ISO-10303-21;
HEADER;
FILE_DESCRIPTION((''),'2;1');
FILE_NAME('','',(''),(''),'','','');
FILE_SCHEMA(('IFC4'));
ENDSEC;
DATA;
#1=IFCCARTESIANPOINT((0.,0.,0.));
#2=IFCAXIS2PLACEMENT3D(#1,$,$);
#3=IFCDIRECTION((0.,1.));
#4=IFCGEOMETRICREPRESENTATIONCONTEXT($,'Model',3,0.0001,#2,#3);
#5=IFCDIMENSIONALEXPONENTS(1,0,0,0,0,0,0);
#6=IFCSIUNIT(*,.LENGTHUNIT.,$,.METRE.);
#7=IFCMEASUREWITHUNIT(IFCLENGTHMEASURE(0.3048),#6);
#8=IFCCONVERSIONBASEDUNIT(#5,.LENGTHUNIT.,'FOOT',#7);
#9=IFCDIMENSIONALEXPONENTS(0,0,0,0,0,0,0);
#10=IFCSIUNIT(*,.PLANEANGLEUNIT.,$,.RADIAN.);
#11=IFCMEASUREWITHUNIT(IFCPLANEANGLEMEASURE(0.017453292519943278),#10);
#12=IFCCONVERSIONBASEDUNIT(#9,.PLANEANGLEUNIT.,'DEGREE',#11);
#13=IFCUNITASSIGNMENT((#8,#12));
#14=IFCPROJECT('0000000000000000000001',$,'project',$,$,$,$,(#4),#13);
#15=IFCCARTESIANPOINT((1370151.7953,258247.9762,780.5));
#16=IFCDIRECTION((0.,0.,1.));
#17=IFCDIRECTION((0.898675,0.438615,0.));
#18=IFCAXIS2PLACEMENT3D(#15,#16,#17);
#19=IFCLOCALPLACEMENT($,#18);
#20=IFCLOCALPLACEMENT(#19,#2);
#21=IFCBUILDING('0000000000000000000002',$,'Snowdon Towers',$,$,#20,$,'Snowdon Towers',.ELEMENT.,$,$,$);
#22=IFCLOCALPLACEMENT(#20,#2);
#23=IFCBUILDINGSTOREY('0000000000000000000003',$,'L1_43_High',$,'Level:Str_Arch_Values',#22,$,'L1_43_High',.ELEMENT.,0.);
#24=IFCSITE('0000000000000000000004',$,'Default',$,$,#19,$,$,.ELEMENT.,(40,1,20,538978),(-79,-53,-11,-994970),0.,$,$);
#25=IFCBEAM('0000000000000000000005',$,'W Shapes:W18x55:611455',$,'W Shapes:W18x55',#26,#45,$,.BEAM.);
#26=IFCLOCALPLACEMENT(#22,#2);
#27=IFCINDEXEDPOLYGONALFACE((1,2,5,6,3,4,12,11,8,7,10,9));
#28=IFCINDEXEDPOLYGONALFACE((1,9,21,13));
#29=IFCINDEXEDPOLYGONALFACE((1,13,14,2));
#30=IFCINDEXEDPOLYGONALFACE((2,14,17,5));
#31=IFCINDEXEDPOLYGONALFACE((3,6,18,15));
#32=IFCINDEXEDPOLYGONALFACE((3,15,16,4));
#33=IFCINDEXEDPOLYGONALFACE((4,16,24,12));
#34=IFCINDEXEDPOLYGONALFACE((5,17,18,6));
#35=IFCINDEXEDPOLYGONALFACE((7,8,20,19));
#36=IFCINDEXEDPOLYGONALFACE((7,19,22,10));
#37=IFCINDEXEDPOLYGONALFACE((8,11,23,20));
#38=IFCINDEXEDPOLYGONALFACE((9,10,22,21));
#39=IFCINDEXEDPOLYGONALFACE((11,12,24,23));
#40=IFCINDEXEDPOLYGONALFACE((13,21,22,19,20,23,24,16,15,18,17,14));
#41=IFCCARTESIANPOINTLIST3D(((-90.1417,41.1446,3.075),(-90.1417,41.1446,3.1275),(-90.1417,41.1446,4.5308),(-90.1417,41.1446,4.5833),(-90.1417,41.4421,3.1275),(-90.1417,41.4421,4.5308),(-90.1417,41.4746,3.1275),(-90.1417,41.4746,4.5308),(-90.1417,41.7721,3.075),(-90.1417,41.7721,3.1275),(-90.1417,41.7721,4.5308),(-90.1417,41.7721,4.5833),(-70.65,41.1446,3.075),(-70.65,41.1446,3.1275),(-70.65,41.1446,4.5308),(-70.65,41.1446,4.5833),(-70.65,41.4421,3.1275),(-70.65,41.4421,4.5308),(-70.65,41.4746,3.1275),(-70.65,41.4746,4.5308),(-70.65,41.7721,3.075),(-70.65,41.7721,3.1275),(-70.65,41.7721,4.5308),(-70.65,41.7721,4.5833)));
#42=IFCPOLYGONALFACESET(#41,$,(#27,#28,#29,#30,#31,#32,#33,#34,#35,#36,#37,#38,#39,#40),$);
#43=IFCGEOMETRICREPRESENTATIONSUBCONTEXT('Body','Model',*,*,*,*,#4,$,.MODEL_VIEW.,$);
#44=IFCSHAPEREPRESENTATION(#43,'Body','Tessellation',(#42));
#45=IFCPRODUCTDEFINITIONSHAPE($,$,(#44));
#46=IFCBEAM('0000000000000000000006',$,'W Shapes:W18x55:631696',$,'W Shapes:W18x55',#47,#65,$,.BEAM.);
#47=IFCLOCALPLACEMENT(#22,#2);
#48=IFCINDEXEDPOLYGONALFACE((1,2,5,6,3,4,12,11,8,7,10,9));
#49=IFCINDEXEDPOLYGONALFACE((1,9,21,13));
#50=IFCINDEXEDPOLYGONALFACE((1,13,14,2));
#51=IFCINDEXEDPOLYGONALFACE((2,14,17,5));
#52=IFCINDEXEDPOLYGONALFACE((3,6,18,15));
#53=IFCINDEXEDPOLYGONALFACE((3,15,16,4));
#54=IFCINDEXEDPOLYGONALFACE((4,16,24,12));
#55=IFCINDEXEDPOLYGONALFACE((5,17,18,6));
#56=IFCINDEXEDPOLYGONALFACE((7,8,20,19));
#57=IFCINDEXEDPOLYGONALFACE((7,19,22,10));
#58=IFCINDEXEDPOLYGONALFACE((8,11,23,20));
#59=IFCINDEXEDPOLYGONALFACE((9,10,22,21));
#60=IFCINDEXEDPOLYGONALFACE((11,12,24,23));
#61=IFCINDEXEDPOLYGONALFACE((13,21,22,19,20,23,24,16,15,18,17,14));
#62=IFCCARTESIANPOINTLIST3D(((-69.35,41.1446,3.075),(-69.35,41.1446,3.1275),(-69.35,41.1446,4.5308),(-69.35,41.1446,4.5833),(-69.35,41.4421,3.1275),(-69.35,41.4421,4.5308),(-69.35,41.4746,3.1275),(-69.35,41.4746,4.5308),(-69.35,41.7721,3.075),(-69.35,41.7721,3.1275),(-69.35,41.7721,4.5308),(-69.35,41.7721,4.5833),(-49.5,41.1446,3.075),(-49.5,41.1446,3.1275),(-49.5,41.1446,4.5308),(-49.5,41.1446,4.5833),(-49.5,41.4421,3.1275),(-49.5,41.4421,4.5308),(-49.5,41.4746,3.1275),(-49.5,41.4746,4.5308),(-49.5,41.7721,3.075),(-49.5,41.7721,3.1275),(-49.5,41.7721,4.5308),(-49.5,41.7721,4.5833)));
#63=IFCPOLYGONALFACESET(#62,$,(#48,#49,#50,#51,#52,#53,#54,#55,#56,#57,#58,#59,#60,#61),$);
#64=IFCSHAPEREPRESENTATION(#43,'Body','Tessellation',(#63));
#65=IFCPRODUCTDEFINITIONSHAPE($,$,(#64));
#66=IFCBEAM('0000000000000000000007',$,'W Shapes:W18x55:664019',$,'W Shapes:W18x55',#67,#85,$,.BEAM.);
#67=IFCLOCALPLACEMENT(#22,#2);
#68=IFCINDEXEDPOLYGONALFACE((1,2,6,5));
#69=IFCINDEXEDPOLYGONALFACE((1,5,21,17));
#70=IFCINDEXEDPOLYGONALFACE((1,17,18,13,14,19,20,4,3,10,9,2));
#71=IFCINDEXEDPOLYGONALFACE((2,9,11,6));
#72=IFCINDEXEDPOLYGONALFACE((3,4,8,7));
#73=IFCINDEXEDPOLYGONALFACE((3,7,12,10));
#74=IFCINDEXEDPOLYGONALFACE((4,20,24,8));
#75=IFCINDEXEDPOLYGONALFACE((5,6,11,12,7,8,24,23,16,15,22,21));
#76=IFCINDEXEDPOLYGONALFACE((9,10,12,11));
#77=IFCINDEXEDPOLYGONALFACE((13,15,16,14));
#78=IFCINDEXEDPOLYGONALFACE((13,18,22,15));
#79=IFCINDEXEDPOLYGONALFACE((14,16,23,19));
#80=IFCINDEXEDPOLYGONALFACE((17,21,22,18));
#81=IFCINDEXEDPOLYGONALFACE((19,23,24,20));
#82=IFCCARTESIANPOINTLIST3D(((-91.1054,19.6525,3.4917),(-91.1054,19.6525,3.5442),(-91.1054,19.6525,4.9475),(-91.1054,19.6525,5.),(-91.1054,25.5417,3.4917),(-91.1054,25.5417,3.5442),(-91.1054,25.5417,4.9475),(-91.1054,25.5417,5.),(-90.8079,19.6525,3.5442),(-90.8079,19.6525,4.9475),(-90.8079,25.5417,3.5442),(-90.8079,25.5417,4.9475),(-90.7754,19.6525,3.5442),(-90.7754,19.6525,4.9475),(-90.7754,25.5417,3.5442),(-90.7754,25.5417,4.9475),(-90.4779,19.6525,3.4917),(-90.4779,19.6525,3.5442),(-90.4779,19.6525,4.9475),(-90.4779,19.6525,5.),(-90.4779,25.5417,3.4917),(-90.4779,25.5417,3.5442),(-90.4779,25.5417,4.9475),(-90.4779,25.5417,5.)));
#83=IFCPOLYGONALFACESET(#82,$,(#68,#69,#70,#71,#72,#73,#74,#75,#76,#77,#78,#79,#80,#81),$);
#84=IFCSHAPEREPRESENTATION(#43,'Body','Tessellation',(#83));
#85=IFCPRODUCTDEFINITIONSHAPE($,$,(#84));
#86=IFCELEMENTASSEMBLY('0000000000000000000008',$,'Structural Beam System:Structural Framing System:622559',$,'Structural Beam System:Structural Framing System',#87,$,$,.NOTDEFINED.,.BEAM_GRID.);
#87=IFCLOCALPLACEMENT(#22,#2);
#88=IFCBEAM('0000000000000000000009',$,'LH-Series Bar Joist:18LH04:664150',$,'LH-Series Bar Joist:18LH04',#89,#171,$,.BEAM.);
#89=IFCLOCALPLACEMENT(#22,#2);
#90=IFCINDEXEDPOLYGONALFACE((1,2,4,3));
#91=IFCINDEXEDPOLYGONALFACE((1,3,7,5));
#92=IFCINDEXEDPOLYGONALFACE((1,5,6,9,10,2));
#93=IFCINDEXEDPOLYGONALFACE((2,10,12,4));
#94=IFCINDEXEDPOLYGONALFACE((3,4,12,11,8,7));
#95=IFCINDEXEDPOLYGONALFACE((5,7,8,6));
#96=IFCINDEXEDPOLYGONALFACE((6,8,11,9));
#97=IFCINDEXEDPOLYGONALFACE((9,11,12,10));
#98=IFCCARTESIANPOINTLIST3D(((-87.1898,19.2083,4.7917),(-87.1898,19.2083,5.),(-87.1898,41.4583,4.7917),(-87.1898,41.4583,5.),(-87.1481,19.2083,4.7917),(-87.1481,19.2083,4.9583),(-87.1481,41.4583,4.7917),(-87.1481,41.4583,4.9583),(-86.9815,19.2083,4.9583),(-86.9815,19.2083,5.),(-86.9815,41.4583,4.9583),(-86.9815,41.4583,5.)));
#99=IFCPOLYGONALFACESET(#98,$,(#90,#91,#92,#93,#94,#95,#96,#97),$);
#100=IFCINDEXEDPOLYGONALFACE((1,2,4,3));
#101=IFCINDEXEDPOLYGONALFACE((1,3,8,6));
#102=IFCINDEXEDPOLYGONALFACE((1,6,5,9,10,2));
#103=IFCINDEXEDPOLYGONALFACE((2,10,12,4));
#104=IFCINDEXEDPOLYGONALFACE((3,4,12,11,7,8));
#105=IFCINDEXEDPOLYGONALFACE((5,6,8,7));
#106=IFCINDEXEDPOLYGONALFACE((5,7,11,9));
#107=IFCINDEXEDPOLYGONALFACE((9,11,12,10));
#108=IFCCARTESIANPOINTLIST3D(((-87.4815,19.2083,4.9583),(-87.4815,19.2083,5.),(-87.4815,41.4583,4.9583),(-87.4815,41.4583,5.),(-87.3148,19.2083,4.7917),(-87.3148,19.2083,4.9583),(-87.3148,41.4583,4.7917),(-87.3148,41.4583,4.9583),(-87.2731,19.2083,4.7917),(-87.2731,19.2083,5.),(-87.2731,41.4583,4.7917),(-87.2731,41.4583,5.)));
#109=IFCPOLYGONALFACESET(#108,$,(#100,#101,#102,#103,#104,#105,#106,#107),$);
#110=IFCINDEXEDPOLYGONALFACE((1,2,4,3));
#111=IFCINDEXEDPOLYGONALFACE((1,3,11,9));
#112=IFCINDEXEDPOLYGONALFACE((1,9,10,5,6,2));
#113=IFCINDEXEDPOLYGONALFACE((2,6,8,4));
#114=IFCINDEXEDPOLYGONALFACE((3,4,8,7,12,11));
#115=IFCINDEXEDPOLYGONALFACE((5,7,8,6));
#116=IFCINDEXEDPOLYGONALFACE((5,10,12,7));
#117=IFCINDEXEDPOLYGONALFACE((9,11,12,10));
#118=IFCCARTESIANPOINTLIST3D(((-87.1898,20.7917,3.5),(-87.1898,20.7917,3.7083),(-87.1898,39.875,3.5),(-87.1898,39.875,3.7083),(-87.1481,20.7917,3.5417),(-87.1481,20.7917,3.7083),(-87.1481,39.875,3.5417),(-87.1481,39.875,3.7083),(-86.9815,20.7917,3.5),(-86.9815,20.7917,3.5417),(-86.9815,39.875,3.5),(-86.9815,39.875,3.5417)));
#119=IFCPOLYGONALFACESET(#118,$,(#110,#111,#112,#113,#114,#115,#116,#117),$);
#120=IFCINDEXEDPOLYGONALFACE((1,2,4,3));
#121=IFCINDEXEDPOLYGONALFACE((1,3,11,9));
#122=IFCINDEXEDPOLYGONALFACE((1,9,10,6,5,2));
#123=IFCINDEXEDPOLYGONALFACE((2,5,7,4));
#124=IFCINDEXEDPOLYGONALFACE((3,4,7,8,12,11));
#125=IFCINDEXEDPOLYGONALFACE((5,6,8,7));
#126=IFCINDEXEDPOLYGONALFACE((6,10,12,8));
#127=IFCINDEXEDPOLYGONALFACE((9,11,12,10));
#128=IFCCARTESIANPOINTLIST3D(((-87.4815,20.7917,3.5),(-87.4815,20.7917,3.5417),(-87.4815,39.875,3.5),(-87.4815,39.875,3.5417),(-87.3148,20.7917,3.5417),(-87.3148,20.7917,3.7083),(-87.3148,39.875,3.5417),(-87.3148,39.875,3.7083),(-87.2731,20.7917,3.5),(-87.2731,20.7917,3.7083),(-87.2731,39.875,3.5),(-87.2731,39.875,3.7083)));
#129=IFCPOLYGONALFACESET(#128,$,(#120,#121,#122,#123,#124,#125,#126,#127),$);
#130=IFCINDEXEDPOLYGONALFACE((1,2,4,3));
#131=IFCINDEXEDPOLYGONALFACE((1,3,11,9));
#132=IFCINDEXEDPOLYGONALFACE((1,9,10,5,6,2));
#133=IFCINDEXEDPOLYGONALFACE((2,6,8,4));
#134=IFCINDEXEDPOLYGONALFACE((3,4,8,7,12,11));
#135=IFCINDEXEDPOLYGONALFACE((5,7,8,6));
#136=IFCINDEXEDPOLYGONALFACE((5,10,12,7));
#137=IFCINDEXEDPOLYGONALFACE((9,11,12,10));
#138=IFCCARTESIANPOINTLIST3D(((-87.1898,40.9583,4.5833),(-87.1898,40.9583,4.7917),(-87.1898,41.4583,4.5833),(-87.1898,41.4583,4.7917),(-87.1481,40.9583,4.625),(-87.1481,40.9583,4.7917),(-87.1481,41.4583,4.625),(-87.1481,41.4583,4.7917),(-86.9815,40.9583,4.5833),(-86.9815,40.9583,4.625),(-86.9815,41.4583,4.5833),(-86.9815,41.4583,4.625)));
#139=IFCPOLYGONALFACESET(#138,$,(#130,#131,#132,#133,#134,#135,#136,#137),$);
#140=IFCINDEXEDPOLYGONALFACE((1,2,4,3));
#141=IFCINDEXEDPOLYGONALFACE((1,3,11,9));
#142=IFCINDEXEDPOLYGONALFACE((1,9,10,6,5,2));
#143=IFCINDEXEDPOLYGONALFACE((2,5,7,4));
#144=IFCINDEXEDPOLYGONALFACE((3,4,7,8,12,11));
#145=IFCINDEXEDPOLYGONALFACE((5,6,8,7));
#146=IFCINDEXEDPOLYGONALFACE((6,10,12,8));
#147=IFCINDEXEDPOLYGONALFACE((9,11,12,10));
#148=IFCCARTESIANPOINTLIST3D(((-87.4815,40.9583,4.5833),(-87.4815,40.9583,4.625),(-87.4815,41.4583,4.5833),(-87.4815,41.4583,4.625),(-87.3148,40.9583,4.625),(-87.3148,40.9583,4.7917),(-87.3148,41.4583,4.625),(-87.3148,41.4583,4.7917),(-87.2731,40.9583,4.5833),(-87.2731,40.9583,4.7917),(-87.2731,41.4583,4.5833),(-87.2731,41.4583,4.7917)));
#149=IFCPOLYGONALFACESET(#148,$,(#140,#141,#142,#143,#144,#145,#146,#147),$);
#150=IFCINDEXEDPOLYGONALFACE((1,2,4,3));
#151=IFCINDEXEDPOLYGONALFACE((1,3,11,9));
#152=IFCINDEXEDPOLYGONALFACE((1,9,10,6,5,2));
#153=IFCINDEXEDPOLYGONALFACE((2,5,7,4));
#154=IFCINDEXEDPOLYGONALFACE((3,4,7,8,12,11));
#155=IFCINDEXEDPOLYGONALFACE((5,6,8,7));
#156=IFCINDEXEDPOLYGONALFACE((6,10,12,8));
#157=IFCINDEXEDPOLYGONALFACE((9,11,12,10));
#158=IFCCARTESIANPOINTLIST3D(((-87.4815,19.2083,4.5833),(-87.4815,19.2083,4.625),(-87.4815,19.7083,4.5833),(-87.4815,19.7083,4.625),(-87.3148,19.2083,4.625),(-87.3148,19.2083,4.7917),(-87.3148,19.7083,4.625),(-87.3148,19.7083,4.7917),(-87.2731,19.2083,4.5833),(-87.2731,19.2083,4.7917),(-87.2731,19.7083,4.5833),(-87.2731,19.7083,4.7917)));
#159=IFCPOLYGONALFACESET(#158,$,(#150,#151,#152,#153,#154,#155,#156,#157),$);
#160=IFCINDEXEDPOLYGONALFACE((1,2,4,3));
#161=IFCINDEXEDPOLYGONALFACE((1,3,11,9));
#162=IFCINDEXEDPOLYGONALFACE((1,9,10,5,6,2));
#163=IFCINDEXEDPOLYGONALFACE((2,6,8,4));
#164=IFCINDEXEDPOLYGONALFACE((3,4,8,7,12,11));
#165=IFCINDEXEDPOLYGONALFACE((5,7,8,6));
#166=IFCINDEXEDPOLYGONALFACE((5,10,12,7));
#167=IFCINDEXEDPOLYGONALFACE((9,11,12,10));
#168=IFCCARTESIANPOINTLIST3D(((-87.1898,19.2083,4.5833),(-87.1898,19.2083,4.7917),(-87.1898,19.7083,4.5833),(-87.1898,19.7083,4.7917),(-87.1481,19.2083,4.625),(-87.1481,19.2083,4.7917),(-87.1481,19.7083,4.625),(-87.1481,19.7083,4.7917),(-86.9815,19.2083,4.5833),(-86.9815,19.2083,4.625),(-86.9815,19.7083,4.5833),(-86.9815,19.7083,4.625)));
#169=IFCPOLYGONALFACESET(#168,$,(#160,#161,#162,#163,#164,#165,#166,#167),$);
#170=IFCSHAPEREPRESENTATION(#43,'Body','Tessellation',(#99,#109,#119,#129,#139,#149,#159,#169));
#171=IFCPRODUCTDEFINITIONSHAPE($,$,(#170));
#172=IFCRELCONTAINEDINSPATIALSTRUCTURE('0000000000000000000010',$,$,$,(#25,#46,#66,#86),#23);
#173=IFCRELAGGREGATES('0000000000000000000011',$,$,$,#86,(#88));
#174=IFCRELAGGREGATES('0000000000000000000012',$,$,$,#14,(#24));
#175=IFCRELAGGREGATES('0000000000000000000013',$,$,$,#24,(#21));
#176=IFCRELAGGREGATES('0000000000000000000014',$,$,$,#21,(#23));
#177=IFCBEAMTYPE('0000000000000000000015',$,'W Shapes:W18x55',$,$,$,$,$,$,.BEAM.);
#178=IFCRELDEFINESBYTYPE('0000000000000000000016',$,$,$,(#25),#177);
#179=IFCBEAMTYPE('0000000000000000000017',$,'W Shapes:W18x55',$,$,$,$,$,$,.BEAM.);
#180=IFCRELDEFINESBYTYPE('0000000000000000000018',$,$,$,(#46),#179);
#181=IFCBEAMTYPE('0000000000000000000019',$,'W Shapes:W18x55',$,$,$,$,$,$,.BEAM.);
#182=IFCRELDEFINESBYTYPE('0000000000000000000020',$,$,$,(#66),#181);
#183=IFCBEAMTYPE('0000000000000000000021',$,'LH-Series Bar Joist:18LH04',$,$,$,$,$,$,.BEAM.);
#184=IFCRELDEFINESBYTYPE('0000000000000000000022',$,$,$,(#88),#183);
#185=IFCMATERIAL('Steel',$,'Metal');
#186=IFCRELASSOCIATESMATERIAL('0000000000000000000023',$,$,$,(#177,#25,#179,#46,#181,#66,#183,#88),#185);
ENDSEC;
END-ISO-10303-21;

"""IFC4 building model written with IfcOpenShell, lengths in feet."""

from ifc_helpers import new_model, entity, si_unit, converted_unit, direction, frame, origin, place, context, subcontext, project, spatial, indexed_curve, outline, extrude, source, transform, mapped, material, type_object, type_shapes, element, aggregate, save


model = new_model("IFC4")

# Units and contexts
model_context = context("Model", 3, precision=0.0001, world=origin(), true_north=direction((0.0, 1.0)))
body_context = subcontext(model_context, "Body", "Model", "MODEL_VIEW")
ifc_project = project(units=[converted_unit("LENGTHUNIT", "FOOT", entity("IfcLengthMeasure", 0.3048), si_unit("LENGTHUNIT", "METRE"), dimensions=[1, 0, 0, 0, 0, 0, 0]), converted_unit("PLANEANGLEUNIT", "DEGREE", entity("IfcPlaneAngleMeasure", 0.017453292519943278), si_unit("PLANEANGLEUNIT", "RADIAN"), dimensions=[0, 0, 0, 0, 0, 0, 0])], contexts=[model_context])

# Site, building, storey
site_placement = place(None, frame((1370151.7953, 258247.9762, 780.5), z_axis=(0.0, 0.0, 1.0), x_axis=(0.898675, 0.438615, 0.0)))
site = spatial("IfcSite", under=ifc_project, at=site_placement, Name="Default", CompositionType="ELEMENT", RefLatitude=(40, 1, 20, 538978), RefLongitude=(-79, -53, -11, -994970), RefElevation=0.0)
building_placement = place(site_placement, origin())
building = spatial("IfcBuilding", under=site, at=building_placement, Name="Snowdon Towers", LongName="Snowdon Towers", CompositionType="ELEMENT")
storey_placement = place(building_placement, origin())
storey = spatial("IfcBuildingStorey", under=building, at=storey_placement, Name="L1_43_High", ObjectType="Level:Str_Arch_Values", LongName="L1_43_High", CompositionType="ELEMENT", Elevation=0.0)

# Shared definitions
ifc_material_1 = material(Name="Steel", Category="Metal")

# Beams
beam_type_1 = type_object("IfcBeamType", Name="W Shapes:W18x55", PredefinedType="BEAM", material=ifc_material_1)
shared_shape_1 = source(origin(), body_context, "Body", "SweptSolid", [
    extrude(outline(indexed_curve([(-0.3138, -0.7017), (-0.3138, -0.7542), (0.3138, -0.7542), (0.3138, -0.7017), (0.0162, -0.7017), (0.0162, 0.7017), (0.3138, 0.7017), (0.3138, 0.7542), (-0.3137, 0.7542), (-0.3137, 0.7017), (-0.0163, 0.7017), (-0.0163, -0.7017), (-0.3138, -0.7017)], self_intersect=False)), frame((-9.7875, 0.0, 0.0), z_axis=(-1.0, 0.0, 0.0), x_axis=(0.0, -1.0, 0.0)), (0.0, 0.0, -1.0), 19.4917),
])
type_shapes(beam_type_1, [shared_shape_1])
beam_1_placement = place(storey_placement, frame((-80.3542, 41.4583, 3.8292)))
element("IfcBeam", 1, at=beam_1_placement, inside=storey, type_object=beam_type_1, material=ifc_material_1, Name="W Shapes:W18x55:611455", ObjectType="W Shapes:W18x55", PredefinedType="BEAM", context=body_context, shape_type="MappedRepresentation", body=[
    mapped(shared_shape_1, transform((0.0, 0.0, 0.0), scale=1.0)),
])
beam_type_2 = type_object("IfcBeamType", Name="W Shapes:W18x55", PredefinedType="BEAM", material=ifc_material_1)
shared_shape_2 = source(origin(), body_context, "Body", "SweptSolid", [
    extrude(outline(indexed_curve([(-0.3138, -0.7017), (-0.3138, -0.7542), (0.3138, -0.7542), (0.3138, -0.7017), (0.0162, -0.7017), (0.0162, 0.7017), (0.3138, 0.7017), (0.3138, 0.7542), (-0.3137, 0.7542), (-0.3137, 0.7017), (-0.0163, 0.7017), (-0.0163, -0.7017), (-0.3138, -0.7017)], self_intersect=False)), frame((-9.725, 0.0, 0.0), z_axis=(-1.0, 0.0, 0.0), x_axis=(0.0, -1.0, 0.0)), (0.0, 0.0, -1.0), 19.85),
])
type_shapes(beam_type_2, [shared_shape_2])
beam_2_placement = place(storey_placement, frame((-59.625, 41.4583, 3.8292)))
element("IfcBeam", 2, at=beam_2_placement, inside=storey, type_object=beam_type_2, material=ifc_material_1, Name="W Shapes:W18x55:631696", ObjectType="W Shapes:W18x55", PredefinedType="BEAM", context=body_context, shape_type="MappedRepresentation", body=[
    mapped(shared_shape_2, transform((0.0, 0.0, 0.0), scale=1.0)),
])
beam_type_3 = type_object("IfcBeamType", Name="W Shapes:W18x55", PredefinedType="BEAM", material=ifc_material_1)
shared_shape_3 = source(origin(), body_context, "Body", "SweptSolid", [
    extrude(outline(indexed_curve([(-0.3138, -0.7017), (-0.3138, -0.7542), (0.3138, -0.7542), (0.3138, -0.7017), (0.0162, -0.7017), (0.0162, 0.7017), (0.3138, 0.7017), (0.3138, 0.7542), (-0.3137, 0.7542), (-0.3137, 0.7017), (-0.0163, 0.7017), (-0.0163, -0.7017), (-0.3138, -0.7017)], self_intersect=False)), frame((-2.7154, 0.0, 0.0), z_axis=(-1.0, 0.0, 0.0), x_axis=(0.0, -1.0, 0.0)), (0.0, 0.0, -1.0), 5.8892),
])
type_shapes(beam_type_3, [shared_shape_3])
beam_3_placement = place(storey_placement, frame((-90.7917, 22.3679, 4.2458), z_axis=(0.0, 0.0, 1.0), x_axis=(0.0, 1.0, 0.0)))
element("IfcBeam", 3, at=beam_3_placement, inside=storey, type_object=beam_type_3, material=ifc_material_1, Name="W Shapes:W18x55:664019", ObjectType="W Shapes:W18x55", PredefinedType="BEAM", context=body_context, shape_type="MappedRepresentation", body=[
    mapped(shared_shape_3, transform((0.0, 0.0, 0.0), scale=1.0)),
])

# Element assembly, beam
assembly_placement = place(storey_placement, origin())
assembly = element("IfcElementAssembly", 4, at=assembly_placement, inside=storey, Name="Structural Beam System:Structural Framing System:622559", ObjectType="Structural Beam System:Structural Framing System", AssemblyPlace="NOTDEFINED", PredefinedType="BEAM_GRID")
beam_type_4 = type_object("IfcBeamType", Name="LH-Series Bar Joist:18LH04", PredefinedType="BEAM", material=ifc_material_1)
shared_shape_4 = source(origin(), body_context, "Body", "SweptSolid", [
    extrude(outline(indexed_curve([(-0.0833, -0.0833), (0.125, -0.0833), (0.125, -0.0417), (-0.0417, -0.0417), (-0.0417, 0.125), (-0.0833, 0.125), (-0.0833, -0.0833)], self_intersect=False)), frame((-11.125, -0.125, 0.6667), z_axis=(1.0, 0.0, 0.0), x_axis=(0.0, -1.0, 0.0)), (0.0, 0.0, 1.0), 22.25),
    extrude(outline(indexed_curve([(-0.0833, -0.0833), (0.125, -0.0833), (0.125, -0.0417), (-0.0417, -0.0417), (-0.0417, 0.125), (-0.0833, 0.125), (-0.0833, -0.0833)], self_intersect=False)), frame((-11.125, 0.125, 0.6667), z_axis=(1.0, 0.0, 0.0), x_axis=(0.0, 0.0, -1.0)), (0.0, 0.0, 1.0), 22.25),
    extrude(outline(indexed_curve([(-0.0833, -0.0833), (0.125, -0.0833), (0.125, -0.0417), (-0.0417, -0.0417), (-0.0417, 0.125), (-0.0833, 0.125), (-0.0833, -0.0833)], self_intersect=False)), frame((-9.5417, -0.125, -0.6667), z_axis=(1.0, 0.0, 0.0), x_axis=(0.0, 0.0, 1.0)), (0.0, 0.0, 1.0), 19.0833),
    extrude(outline(indexed_curve([(-0.0833, -0.0833), (0.125, -0.0833), (0.125, -0.0417), (-0.0417, -0.0417), (-0.0417, 0.125), (-0.0833, 0.125), (-0.0833, -0.0833)], self_intersect=False)), frame((-9.5417, 0.125, -0.6667), z_axis=(1.0, 0.0, 0.0), x_axis=(0.0, 1.0, 0.0)), (0.0, 0.0, 1.0), 19.0833),
    extrude(outline(indexed_curve([(-0.0833, -0.0833), (0.125, -0.0833), (0.125, -0.0417), (-0.0417, -0.0417), (-0.0417, 0.125), (-0.0833, 0.125), (-0.0833, -0.0833)], self_intersect=False)), frame((10.625, -0.125, 0.4167), z_axis=(1.0, 0.0, 0.0), x_axis=(0.0, 0.0, 1.0)), (0.0, 0.0, 1.0), 0.5),
    extrude(outline(indexed_curve([(-0.0833, -0.0833), (0.125, -0.0833), (0.125, -0.0417), (-0.0417, -0.0417), (-0.0417, 0.125), (-0.0833, 0.125), (-0.0833, -0.0833)], self_intersect=False)), frame((10.625, 0.125, 0.4167), z_axis=(1.0, 0.0, 0.0), x_axis=(0.0, 1.0, 0.0)), (0.0, 0.0, 1.0), 0.5),
    extrude(outline(indexed_curve([(-0.0833, -0.125), (-0.0417, -0.125), (-0.0417, 0.0417), (0.125, 0.0417), (0.125, 0.0833), (-0.0833, 0.0833), (-0.0833, -0.125)], self_intersect=False)), frame((-11.125, 0.125, 0.4167), z_axis=(1.0, 0.0, 0.0), x_axis=(0.0, 0.0, 1.0)), (0.0, 0.0, 1.0), 0.5),
    extrude(outline(indexed_curve([(-0.0833, -0.0833), (0.125, -0.0833), (0.125, -0.0417), (-0.0417, -0.0417), (-0.0417, 0.125), (-0.0833, 0.125), (-0.0833, -0.0833)], self_intersect=False)), frame((-11.125, -0.125, 0.4167), z_axis=(1.0, 0.0, 0.0), x_axis=(0.0, 0.0, 1.0)), (0.0, 0.0, 1.0), 0.5),
])
type_shapes(beam_type_4, [shared_shape_4])
beam_4_placement = place(assembly_placement, frame((-87.2315, 30.3333, 4.25), z_axis=(0.0, 0.0, 1.0), x_axis=(0.0, 1.0, 0.0)))
beam_4 = element("IfcBeam", 5, at=beam_4_placement, type_object=beam_type_4, material=ifc_material_1, Name="LH-Series Bar Joist:18LH04:664150", ObjectType="LH-Series Bar Joist:18LH04", PredefinedType="BEAM", context=body_context, shape_type="MappedRepresentation", body=[
    mapped(shared_shape_4, transform((0.0, 0.0, 0.0), scale=1.0)),
])
aggregate(assembly, [beam_4])

save(model, "model.ifc")
